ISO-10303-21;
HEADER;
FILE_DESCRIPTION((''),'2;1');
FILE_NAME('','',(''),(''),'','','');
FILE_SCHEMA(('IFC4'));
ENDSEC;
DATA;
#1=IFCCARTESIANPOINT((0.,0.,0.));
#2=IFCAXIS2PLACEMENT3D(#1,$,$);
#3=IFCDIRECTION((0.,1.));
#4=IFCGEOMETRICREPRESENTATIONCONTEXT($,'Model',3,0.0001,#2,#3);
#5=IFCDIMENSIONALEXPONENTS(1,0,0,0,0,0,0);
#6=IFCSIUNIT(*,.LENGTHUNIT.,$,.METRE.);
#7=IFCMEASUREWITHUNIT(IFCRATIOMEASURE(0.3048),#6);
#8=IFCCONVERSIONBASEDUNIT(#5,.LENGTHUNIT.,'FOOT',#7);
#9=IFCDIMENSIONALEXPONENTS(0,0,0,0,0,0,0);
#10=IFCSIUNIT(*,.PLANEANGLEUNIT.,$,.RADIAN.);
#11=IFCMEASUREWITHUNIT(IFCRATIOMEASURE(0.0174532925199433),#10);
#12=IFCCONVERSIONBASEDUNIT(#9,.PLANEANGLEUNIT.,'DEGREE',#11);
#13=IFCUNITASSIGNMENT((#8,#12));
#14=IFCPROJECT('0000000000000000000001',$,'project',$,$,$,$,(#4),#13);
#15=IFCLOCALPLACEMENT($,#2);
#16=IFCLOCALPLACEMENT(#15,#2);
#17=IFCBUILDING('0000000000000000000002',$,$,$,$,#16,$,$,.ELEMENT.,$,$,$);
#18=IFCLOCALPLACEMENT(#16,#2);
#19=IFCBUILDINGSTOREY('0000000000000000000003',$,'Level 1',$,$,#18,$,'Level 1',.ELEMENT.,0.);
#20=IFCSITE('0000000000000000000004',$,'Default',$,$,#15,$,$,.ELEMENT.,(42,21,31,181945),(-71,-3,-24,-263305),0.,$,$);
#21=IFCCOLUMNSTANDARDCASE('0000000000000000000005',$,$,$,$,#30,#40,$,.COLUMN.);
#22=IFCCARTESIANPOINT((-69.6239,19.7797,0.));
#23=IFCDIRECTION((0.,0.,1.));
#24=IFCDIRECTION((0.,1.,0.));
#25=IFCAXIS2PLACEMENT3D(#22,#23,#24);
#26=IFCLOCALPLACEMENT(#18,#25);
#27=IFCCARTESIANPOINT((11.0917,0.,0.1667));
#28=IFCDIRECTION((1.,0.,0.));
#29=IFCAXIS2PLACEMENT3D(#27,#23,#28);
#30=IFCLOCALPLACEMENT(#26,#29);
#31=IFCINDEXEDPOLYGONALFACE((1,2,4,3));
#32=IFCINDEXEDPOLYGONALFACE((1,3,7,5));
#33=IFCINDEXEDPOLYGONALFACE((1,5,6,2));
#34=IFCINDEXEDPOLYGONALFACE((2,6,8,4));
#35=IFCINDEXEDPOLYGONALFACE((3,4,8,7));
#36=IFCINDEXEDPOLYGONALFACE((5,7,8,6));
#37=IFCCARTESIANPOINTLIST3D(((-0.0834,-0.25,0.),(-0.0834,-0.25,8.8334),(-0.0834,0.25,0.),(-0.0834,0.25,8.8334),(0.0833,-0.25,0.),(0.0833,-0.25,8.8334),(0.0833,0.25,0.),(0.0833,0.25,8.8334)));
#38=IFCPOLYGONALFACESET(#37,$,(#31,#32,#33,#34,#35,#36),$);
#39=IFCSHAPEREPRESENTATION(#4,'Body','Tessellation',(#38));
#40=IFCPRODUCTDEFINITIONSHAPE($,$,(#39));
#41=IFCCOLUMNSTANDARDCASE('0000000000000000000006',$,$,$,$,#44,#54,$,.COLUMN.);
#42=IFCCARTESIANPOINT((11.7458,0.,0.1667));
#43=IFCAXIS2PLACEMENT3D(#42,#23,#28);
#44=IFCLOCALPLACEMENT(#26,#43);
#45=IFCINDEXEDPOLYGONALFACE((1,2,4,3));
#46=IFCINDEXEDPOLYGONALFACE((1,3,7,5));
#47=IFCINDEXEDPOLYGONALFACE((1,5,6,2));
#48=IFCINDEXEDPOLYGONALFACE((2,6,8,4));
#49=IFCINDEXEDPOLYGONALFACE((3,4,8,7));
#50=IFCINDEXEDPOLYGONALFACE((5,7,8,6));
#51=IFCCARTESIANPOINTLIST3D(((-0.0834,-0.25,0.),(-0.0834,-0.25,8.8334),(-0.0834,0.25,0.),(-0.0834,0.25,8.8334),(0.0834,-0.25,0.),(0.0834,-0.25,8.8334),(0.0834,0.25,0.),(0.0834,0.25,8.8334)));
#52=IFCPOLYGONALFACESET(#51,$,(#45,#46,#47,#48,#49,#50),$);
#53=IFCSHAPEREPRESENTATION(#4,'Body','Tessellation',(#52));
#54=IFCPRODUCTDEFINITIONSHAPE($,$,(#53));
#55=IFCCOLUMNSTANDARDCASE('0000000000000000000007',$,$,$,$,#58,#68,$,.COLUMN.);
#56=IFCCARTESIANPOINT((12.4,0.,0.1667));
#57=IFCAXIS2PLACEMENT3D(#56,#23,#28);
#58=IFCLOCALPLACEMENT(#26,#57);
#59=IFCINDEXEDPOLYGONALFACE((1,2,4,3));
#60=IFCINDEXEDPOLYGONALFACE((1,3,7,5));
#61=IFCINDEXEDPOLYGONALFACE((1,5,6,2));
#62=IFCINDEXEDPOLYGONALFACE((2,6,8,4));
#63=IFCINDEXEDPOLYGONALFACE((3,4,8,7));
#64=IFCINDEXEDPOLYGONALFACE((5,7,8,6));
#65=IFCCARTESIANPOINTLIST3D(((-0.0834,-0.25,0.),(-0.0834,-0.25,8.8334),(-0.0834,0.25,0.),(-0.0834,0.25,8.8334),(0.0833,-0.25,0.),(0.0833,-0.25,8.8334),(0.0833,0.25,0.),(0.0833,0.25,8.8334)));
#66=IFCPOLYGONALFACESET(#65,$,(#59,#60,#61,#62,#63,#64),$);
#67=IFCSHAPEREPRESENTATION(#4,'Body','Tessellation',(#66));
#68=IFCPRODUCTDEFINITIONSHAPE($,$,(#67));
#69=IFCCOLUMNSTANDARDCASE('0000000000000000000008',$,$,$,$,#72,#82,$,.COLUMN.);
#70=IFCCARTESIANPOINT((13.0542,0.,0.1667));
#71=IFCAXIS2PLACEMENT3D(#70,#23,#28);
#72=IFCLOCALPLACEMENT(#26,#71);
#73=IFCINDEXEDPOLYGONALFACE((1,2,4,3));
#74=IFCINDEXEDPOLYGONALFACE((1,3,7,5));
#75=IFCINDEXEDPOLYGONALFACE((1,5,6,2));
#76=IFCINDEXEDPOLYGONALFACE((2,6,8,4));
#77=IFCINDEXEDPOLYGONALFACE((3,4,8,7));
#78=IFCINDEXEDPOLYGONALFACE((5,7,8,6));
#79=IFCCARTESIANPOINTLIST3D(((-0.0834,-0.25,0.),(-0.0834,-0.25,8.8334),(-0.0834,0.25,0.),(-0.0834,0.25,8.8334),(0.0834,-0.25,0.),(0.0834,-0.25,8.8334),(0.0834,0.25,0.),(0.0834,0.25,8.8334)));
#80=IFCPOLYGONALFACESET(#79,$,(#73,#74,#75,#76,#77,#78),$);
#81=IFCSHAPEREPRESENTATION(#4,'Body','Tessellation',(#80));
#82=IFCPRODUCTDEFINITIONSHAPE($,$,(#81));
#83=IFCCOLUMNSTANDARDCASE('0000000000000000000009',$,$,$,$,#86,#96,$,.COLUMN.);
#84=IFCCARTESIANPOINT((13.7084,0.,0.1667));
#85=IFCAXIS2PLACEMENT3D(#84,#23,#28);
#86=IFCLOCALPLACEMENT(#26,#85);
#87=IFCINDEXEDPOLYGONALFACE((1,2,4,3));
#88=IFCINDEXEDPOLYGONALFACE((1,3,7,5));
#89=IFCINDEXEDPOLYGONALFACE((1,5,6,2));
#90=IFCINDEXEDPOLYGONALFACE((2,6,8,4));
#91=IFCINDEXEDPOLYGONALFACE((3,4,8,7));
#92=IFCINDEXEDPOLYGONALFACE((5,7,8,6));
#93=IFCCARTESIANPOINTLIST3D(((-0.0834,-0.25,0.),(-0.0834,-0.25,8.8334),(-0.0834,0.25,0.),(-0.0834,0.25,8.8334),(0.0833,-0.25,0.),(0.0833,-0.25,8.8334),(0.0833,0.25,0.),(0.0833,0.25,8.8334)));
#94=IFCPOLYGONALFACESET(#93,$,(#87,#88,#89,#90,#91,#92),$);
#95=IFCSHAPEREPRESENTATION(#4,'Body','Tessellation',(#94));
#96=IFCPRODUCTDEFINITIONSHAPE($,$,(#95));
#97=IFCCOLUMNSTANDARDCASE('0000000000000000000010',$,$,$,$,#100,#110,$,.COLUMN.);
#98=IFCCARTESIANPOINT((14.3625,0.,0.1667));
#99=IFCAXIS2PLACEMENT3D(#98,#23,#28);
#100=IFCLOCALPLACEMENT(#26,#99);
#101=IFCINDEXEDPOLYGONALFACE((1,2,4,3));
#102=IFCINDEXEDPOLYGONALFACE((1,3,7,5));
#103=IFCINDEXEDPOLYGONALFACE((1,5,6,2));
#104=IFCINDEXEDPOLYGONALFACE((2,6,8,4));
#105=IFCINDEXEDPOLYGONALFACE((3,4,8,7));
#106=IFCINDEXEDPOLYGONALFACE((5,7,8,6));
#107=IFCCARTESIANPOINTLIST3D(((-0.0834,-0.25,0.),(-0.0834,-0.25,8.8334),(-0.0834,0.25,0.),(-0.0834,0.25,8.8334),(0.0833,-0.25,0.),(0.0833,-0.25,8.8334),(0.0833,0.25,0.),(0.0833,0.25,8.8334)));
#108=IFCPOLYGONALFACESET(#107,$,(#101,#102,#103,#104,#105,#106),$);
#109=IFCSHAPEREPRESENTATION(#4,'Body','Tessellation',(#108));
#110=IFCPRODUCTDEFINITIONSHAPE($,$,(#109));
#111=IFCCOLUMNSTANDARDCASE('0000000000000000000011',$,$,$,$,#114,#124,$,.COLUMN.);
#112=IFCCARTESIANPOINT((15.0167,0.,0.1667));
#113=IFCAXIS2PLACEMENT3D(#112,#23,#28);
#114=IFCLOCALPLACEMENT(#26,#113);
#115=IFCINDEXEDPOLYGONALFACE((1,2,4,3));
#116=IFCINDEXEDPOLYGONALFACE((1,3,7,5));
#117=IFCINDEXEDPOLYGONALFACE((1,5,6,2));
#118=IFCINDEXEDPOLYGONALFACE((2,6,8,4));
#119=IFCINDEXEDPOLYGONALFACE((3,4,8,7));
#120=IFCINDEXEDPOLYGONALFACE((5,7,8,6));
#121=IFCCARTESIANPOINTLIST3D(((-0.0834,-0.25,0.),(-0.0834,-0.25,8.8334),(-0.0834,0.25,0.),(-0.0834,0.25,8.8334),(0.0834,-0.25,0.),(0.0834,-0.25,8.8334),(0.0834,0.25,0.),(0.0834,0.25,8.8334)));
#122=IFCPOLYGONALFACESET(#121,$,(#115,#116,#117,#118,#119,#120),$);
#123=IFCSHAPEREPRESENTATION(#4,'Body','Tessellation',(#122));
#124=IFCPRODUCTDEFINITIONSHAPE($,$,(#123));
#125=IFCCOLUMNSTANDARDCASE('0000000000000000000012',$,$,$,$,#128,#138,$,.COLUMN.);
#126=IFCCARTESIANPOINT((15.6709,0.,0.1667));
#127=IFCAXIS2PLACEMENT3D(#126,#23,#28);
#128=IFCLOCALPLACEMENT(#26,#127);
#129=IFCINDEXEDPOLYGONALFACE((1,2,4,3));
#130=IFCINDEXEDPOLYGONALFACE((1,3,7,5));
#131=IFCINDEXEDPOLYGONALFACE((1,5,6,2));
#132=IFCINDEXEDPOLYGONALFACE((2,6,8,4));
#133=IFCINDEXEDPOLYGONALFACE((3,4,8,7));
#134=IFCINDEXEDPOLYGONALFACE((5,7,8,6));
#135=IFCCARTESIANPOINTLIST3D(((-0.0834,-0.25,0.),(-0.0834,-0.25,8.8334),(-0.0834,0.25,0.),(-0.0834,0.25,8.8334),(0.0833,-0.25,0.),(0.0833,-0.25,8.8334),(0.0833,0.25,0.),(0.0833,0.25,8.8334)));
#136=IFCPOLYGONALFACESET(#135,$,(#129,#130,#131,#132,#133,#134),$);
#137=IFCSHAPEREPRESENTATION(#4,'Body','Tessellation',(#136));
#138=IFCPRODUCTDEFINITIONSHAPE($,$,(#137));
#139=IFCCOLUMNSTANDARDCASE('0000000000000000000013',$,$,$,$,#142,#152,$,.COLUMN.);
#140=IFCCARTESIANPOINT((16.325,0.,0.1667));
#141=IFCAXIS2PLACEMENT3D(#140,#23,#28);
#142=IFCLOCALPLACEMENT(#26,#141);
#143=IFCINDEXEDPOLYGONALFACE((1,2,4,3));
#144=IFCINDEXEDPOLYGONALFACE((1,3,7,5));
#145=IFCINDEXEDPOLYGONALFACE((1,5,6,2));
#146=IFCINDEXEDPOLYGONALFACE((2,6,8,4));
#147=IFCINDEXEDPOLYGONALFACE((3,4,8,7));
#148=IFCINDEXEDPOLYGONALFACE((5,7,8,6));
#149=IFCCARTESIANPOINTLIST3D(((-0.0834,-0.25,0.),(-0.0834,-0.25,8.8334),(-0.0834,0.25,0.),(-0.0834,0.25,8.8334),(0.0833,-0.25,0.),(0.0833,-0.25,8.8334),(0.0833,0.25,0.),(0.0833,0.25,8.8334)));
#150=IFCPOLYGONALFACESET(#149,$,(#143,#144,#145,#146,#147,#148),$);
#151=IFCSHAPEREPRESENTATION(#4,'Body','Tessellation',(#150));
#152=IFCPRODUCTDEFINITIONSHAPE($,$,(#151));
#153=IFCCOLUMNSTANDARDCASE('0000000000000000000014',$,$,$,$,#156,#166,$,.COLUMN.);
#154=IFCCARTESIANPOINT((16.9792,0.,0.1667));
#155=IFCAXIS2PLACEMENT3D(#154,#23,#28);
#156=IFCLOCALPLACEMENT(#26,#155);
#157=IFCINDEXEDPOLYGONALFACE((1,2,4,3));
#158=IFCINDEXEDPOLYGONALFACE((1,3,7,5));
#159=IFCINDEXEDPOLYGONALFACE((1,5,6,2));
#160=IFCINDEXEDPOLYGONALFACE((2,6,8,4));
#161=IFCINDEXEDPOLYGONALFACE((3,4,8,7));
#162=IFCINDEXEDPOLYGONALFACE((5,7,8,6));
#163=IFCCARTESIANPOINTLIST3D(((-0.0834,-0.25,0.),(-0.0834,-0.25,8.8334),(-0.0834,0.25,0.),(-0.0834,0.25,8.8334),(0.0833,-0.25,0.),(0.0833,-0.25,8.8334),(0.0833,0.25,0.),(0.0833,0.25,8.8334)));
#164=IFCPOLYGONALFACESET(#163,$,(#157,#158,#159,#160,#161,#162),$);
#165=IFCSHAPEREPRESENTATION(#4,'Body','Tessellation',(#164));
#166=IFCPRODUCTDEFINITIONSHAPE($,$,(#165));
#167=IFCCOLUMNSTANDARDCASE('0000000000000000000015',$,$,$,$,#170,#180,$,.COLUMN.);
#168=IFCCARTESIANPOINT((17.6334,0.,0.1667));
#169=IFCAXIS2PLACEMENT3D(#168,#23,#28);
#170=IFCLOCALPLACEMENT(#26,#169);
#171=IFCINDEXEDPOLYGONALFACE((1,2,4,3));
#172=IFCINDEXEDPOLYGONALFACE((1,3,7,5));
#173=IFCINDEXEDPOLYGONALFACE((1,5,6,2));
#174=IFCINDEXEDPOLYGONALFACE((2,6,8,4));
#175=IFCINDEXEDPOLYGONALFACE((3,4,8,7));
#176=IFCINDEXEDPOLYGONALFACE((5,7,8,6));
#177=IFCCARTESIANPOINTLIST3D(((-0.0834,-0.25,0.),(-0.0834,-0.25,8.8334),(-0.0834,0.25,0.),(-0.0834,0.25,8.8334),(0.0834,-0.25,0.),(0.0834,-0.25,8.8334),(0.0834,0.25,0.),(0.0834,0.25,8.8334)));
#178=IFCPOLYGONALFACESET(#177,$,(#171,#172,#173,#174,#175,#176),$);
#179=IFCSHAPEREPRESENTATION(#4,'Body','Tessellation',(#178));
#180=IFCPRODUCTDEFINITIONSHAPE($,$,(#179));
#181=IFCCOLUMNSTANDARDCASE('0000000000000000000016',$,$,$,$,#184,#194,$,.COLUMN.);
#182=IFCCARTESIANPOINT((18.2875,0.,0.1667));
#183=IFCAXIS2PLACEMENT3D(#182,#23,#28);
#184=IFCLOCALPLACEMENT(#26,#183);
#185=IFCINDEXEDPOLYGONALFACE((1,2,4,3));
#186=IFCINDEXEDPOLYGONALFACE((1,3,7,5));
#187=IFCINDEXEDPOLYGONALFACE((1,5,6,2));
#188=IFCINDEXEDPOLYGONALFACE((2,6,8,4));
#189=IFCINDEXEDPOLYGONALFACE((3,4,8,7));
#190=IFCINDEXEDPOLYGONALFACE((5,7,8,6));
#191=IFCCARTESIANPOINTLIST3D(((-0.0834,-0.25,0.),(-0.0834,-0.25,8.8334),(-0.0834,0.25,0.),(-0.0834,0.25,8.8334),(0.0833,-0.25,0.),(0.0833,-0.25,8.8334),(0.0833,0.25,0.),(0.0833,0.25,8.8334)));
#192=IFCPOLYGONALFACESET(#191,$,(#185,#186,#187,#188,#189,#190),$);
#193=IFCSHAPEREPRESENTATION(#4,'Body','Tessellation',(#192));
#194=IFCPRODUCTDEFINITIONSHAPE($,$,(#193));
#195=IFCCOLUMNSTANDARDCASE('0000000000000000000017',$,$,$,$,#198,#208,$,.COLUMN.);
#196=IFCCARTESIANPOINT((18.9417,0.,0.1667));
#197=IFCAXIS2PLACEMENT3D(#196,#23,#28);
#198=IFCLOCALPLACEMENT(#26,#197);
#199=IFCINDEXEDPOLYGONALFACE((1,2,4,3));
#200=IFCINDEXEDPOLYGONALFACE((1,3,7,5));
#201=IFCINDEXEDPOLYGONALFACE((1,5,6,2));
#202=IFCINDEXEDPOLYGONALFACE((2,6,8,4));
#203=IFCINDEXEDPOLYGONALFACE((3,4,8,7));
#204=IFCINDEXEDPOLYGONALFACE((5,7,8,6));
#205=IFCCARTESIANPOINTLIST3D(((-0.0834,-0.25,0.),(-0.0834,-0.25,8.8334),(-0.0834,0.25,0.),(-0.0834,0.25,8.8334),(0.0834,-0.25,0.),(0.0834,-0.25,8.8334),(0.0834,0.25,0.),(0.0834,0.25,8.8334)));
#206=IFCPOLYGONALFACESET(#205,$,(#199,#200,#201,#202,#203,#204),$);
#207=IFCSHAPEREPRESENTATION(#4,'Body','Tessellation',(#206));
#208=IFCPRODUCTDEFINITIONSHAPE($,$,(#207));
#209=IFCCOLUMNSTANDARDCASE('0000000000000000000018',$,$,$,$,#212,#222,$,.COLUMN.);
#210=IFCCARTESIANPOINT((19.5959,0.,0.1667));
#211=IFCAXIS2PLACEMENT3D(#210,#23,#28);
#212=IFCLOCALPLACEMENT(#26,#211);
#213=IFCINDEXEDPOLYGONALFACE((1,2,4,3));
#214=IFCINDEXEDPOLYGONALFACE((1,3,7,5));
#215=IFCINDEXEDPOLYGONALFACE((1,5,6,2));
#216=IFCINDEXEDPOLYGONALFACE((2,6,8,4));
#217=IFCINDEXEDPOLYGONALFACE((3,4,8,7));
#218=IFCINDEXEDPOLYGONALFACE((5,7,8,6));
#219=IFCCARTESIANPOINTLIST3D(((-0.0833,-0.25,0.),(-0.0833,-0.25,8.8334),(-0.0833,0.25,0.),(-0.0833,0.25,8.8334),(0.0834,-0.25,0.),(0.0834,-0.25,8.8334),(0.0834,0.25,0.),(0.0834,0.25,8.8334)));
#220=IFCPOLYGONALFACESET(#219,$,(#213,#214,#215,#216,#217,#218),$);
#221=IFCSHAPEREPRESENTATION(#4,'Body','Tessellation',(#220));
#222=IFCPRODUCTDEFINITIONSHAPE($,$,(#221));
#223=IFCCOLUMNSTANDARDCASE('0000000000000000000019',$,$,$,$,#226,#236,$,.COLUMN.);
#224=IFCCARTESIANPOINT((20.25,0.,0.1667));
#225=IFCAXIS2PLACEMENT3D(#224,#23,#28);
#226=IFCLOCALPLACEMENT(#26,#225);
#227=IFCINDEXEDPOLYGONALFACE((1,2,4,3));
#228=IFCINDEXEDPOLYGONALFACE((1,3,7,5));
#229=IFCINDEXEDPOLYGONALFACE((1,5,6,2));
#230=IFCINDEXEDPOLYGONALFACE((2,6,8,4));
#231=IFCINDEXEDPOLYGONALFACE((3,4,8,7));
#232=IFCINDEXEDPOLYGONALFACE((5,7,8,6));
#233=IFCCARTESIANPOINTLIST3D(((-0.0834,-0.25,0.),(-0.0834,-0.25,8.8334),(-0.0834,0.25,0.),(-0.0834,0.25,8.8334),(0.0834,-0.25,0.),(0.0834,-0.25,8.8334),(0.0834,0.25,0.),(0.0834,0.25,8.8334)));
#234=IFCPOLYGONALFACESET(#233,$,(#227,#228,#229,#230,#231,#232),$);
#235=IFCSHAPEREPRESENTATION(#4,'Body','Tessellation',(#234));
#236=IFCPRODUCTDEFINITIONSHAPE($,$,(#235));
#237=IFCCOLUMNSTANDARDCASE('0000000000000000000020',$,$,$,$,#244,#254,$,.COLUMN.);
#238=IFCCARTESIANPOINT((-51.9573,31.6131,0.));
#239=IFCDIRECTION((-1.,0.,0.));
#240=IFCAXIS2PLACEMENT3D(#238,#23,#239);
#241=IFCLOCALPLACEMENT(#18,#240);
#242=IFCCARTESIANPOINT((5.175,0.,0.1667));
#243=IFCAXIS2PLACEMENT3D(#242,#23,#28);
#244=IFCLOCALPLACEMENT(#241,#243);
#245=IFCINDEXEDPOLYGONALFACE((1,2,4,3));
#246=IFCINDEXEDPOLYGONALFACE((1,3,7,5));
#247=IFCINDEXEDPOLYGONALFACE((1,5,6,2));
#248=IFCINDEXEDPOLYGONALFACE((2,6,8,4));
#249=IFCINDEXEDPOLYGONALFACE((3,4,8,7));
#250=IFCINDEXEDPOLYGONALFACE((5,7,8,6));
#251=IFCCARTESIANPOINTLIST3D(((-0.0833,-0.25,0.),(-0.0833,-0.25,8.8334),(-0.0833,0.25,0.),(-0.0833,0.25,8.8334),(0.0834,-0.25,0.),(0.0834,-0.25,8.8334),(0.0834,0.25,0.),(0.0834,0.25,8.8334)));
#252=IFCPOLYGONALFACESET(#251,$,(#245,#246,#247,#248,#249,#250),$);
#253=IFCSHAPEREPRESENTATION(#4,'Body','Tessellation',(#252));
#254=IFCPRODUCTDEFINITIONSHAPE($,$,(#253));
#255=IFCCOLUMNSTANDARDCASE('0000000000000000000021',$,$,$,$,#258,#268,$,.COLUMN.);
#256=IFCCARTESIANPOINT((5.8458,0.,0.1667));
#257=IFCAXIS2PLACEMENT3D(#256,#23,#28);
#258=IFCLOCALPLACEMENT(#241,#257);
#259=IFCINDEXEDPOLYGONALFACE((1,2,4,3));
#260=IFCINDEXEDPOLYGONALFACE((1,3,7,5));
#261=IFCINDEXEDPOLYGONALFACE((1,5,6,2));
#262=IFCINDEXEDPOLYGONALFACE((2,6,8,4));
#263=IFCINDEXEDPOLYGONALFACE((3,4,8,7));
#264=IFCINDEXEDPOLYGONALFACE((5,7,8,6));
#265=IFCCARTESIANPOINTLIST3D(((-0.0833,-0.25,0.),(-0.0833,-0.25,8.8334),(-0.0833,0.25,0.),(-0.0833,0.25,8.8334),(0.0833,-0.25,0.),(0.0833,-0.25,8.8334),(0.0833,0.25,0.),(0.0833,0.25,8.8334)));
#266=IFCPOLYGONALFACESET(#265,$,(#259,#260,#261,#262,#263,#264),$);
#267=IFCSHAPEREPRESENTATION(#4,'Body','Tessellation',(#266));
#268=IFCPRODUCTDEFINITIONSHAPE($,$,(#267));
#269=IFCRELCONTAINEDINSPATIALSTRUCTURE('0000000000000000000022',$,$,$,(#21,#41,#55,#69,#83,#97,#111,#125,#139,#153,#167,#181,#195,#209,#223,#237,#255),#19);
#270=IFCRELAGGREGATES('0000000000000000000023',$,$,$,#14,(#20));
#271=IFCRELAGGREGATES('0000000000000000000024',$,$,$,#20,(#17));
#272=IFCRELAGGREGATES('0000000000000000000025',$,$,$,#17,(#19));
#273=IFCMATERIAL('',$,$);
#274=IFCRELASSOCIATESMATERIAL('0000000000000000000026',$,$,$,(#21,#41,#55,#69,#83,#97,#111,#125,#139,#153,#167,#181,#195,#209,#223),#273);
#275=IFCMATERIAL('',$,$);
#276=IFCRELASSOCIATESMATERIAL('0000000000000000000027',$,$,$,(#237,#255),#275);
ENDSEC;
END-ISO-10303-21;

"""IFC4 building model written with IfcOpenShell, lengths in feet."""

from ifc_helpers import new_model, entity, si_unit, converted_unit, direction, frame, origin, place, context, project, spatial, rectangle, extrude, material, element, save


model = new_model("IFC4")

# Units and contexts
model_context = context("Model", 3, precision=0.0001, world=origin(), true_north=direction((0.0, 1.0)))
ifc_project = project(units=[converted_unit("LENGTHUNIT", "FOOT", entity("IfcRatioMeasure", 0.3048), si_unit("LENGTHUNIT", "METRE"), dimensions=[1, 0, 0, 0, 0, 0, 0]), converted_unit("PLANEANGLEUNIT", "DEGREE", entity("IfcRatioMeasure", 0.0174532925199433), si_unit("PLANEANGLEUNIT", "RADIAN"), dimensions=[0, 0, 0, 0, 0, 0, 0])], contexts=[model_context])

# Site, building, storey
site_placement = place(None, origin())
site = spatial("IfcSite", under=ifc_project, at=site_placement, Name="Default", CompositionType="ELEMENT", RefLatitude=(42, 21, 31, 181945), RefLongitude=(-71, -3, -24, -263305), RefElevation=0.0)
building_placement = place(site_placement, origin())
building = spatial("IfcBuilding", under=site, at=building_placement, CompositionType="ELEMENT")
storey_placement = place(building_placement, origin())
storey = spatial("IfcBuildingStorey", under=building, at=storey_placement, Name="Level 1", LongName="Level 1", CompositionType="ELEMENT", Elevation=0.0)

# Columns
ifc_material_1 = material(Name="")
placement_1 = place(storey_placement, frame((-69.6239, 19.7797, 0.0), z_axis=(0.0, 0.0, 1.0), x_axis=(0.0, 1.0, 0.0)))
for number, where, z_axis, x_axis in (
    (1, (11.0917, 0.0, 0.1667), (0.0, 0.0, 1.0), (1.0, 0.0, 0.0)),
    (2, (11.7458, 0.0, 0.1667), (0.0, 0.0, 1.0), (1.0, 0.0, 0.0)),
    (3, (12.4, 0.0, 0.1667), (0.0, 0.0, 1.0), (1.0, 0.0, 0.0)),
    (4, (13.0542, 0.0, 0.1667), (0.0, 0.0, 1.0), (1.0, 0.0, 0.0)),
    (5, (13.7084, 0.0, 0.1667), (0.0, 0.0, 1.0), (1.0, 0.0, 0.0)),
    (6, (14.3625, 0.0, 0.1667), (0.0, 0.0, 1.0), (1.0, 0.0, 0.0)),
    (7, (15.0167, 0.0, 0.1667), (0.0, 0.0, 1.0), (1.0, 0.0, 0.0)),
    (8, (15.6709, 0.0, 0.1667), (0.0, 0.0, 1.0), (1.0, 0.0, 0.0)),
    (9, (16.325, 0.0, 0.1667), (0.0, 0.0, 1.0), (1.0, 0.0, 0.0)),
    (10, (16.9792, 0.0, 0.1667), (0.0, 0.0, 1.0), (1.0, 0.0, 0.0)),
    (11, (17.6334, 0.0, 0.1667), (0.0, 0.0, 1.0), (1.0, 0.0, 0.0)),
    (12, (18.2875, 0.0, 0.1667), (0.0, 0.0, 1.0), (1.0, 0.0, 0.0)),
    (13, (18.9417, 0.0, 0.1667), (0.0, 0.0, 1.0), (1.0, 0.0, 0.0)),
    (14, (19.5959, 0.0, 0.1667), (0.0, 0.0, 1.0), (1.0, 0.0, 0.0)),
    (15, (20.25, 0.0, 0.1667), (0.0, 0.0, 1.0), (1.0, 0.0, 0.0)),
):
    element("IfcColumnStandardCase", number, at=place(placement_1, frame(where, z_axis=z_axis, x_axis=x_axis)), inside=storey, material=ifc_material_1, PredefinedType="COLUMN", context=model_context, shape_type="SweptSolid", body=[
        extrude(rectangle(XDim=0.1667, YDim=0.5), origin(), (0.0, 0.0, 1.0), 8.8334),
    ])
ifc_material_2 = material(Name="")
placement_2 = place(storey_placement, frame((-51.9573, 31.6131, 0.0), z_axis=(0.0, 0.0, 1.0), x_axis=(-1.0, 0.0, 0.0)))
for number, where, z_axis, x_axis in (
    (16, (5.175, 0.0, 0.1667), (0.0, 0.0, 1.0), (1.0, 0.0, 0.0)),
    (17, (5.8458, 0.0, 0.1667), (0.0, 0.0, 1.0), (1.0, 0.0, 0.0)),
):
    element("IfcColumnStandardCase", number, at=place(placement_2, frame(where, z_axis=z_axis, x_axis=x_axis)), inside=storey, material=ifc_material_2, PredefinedType="COLUMN", context=model_context, shape_type="SweptSolid", body=[
        extrude(rectangle(XDim=0.1667, YDim=0.5), origin(), (0.0, 0.0, 1.0), 8.8334),
    ])

save(model, "model.ifc")
